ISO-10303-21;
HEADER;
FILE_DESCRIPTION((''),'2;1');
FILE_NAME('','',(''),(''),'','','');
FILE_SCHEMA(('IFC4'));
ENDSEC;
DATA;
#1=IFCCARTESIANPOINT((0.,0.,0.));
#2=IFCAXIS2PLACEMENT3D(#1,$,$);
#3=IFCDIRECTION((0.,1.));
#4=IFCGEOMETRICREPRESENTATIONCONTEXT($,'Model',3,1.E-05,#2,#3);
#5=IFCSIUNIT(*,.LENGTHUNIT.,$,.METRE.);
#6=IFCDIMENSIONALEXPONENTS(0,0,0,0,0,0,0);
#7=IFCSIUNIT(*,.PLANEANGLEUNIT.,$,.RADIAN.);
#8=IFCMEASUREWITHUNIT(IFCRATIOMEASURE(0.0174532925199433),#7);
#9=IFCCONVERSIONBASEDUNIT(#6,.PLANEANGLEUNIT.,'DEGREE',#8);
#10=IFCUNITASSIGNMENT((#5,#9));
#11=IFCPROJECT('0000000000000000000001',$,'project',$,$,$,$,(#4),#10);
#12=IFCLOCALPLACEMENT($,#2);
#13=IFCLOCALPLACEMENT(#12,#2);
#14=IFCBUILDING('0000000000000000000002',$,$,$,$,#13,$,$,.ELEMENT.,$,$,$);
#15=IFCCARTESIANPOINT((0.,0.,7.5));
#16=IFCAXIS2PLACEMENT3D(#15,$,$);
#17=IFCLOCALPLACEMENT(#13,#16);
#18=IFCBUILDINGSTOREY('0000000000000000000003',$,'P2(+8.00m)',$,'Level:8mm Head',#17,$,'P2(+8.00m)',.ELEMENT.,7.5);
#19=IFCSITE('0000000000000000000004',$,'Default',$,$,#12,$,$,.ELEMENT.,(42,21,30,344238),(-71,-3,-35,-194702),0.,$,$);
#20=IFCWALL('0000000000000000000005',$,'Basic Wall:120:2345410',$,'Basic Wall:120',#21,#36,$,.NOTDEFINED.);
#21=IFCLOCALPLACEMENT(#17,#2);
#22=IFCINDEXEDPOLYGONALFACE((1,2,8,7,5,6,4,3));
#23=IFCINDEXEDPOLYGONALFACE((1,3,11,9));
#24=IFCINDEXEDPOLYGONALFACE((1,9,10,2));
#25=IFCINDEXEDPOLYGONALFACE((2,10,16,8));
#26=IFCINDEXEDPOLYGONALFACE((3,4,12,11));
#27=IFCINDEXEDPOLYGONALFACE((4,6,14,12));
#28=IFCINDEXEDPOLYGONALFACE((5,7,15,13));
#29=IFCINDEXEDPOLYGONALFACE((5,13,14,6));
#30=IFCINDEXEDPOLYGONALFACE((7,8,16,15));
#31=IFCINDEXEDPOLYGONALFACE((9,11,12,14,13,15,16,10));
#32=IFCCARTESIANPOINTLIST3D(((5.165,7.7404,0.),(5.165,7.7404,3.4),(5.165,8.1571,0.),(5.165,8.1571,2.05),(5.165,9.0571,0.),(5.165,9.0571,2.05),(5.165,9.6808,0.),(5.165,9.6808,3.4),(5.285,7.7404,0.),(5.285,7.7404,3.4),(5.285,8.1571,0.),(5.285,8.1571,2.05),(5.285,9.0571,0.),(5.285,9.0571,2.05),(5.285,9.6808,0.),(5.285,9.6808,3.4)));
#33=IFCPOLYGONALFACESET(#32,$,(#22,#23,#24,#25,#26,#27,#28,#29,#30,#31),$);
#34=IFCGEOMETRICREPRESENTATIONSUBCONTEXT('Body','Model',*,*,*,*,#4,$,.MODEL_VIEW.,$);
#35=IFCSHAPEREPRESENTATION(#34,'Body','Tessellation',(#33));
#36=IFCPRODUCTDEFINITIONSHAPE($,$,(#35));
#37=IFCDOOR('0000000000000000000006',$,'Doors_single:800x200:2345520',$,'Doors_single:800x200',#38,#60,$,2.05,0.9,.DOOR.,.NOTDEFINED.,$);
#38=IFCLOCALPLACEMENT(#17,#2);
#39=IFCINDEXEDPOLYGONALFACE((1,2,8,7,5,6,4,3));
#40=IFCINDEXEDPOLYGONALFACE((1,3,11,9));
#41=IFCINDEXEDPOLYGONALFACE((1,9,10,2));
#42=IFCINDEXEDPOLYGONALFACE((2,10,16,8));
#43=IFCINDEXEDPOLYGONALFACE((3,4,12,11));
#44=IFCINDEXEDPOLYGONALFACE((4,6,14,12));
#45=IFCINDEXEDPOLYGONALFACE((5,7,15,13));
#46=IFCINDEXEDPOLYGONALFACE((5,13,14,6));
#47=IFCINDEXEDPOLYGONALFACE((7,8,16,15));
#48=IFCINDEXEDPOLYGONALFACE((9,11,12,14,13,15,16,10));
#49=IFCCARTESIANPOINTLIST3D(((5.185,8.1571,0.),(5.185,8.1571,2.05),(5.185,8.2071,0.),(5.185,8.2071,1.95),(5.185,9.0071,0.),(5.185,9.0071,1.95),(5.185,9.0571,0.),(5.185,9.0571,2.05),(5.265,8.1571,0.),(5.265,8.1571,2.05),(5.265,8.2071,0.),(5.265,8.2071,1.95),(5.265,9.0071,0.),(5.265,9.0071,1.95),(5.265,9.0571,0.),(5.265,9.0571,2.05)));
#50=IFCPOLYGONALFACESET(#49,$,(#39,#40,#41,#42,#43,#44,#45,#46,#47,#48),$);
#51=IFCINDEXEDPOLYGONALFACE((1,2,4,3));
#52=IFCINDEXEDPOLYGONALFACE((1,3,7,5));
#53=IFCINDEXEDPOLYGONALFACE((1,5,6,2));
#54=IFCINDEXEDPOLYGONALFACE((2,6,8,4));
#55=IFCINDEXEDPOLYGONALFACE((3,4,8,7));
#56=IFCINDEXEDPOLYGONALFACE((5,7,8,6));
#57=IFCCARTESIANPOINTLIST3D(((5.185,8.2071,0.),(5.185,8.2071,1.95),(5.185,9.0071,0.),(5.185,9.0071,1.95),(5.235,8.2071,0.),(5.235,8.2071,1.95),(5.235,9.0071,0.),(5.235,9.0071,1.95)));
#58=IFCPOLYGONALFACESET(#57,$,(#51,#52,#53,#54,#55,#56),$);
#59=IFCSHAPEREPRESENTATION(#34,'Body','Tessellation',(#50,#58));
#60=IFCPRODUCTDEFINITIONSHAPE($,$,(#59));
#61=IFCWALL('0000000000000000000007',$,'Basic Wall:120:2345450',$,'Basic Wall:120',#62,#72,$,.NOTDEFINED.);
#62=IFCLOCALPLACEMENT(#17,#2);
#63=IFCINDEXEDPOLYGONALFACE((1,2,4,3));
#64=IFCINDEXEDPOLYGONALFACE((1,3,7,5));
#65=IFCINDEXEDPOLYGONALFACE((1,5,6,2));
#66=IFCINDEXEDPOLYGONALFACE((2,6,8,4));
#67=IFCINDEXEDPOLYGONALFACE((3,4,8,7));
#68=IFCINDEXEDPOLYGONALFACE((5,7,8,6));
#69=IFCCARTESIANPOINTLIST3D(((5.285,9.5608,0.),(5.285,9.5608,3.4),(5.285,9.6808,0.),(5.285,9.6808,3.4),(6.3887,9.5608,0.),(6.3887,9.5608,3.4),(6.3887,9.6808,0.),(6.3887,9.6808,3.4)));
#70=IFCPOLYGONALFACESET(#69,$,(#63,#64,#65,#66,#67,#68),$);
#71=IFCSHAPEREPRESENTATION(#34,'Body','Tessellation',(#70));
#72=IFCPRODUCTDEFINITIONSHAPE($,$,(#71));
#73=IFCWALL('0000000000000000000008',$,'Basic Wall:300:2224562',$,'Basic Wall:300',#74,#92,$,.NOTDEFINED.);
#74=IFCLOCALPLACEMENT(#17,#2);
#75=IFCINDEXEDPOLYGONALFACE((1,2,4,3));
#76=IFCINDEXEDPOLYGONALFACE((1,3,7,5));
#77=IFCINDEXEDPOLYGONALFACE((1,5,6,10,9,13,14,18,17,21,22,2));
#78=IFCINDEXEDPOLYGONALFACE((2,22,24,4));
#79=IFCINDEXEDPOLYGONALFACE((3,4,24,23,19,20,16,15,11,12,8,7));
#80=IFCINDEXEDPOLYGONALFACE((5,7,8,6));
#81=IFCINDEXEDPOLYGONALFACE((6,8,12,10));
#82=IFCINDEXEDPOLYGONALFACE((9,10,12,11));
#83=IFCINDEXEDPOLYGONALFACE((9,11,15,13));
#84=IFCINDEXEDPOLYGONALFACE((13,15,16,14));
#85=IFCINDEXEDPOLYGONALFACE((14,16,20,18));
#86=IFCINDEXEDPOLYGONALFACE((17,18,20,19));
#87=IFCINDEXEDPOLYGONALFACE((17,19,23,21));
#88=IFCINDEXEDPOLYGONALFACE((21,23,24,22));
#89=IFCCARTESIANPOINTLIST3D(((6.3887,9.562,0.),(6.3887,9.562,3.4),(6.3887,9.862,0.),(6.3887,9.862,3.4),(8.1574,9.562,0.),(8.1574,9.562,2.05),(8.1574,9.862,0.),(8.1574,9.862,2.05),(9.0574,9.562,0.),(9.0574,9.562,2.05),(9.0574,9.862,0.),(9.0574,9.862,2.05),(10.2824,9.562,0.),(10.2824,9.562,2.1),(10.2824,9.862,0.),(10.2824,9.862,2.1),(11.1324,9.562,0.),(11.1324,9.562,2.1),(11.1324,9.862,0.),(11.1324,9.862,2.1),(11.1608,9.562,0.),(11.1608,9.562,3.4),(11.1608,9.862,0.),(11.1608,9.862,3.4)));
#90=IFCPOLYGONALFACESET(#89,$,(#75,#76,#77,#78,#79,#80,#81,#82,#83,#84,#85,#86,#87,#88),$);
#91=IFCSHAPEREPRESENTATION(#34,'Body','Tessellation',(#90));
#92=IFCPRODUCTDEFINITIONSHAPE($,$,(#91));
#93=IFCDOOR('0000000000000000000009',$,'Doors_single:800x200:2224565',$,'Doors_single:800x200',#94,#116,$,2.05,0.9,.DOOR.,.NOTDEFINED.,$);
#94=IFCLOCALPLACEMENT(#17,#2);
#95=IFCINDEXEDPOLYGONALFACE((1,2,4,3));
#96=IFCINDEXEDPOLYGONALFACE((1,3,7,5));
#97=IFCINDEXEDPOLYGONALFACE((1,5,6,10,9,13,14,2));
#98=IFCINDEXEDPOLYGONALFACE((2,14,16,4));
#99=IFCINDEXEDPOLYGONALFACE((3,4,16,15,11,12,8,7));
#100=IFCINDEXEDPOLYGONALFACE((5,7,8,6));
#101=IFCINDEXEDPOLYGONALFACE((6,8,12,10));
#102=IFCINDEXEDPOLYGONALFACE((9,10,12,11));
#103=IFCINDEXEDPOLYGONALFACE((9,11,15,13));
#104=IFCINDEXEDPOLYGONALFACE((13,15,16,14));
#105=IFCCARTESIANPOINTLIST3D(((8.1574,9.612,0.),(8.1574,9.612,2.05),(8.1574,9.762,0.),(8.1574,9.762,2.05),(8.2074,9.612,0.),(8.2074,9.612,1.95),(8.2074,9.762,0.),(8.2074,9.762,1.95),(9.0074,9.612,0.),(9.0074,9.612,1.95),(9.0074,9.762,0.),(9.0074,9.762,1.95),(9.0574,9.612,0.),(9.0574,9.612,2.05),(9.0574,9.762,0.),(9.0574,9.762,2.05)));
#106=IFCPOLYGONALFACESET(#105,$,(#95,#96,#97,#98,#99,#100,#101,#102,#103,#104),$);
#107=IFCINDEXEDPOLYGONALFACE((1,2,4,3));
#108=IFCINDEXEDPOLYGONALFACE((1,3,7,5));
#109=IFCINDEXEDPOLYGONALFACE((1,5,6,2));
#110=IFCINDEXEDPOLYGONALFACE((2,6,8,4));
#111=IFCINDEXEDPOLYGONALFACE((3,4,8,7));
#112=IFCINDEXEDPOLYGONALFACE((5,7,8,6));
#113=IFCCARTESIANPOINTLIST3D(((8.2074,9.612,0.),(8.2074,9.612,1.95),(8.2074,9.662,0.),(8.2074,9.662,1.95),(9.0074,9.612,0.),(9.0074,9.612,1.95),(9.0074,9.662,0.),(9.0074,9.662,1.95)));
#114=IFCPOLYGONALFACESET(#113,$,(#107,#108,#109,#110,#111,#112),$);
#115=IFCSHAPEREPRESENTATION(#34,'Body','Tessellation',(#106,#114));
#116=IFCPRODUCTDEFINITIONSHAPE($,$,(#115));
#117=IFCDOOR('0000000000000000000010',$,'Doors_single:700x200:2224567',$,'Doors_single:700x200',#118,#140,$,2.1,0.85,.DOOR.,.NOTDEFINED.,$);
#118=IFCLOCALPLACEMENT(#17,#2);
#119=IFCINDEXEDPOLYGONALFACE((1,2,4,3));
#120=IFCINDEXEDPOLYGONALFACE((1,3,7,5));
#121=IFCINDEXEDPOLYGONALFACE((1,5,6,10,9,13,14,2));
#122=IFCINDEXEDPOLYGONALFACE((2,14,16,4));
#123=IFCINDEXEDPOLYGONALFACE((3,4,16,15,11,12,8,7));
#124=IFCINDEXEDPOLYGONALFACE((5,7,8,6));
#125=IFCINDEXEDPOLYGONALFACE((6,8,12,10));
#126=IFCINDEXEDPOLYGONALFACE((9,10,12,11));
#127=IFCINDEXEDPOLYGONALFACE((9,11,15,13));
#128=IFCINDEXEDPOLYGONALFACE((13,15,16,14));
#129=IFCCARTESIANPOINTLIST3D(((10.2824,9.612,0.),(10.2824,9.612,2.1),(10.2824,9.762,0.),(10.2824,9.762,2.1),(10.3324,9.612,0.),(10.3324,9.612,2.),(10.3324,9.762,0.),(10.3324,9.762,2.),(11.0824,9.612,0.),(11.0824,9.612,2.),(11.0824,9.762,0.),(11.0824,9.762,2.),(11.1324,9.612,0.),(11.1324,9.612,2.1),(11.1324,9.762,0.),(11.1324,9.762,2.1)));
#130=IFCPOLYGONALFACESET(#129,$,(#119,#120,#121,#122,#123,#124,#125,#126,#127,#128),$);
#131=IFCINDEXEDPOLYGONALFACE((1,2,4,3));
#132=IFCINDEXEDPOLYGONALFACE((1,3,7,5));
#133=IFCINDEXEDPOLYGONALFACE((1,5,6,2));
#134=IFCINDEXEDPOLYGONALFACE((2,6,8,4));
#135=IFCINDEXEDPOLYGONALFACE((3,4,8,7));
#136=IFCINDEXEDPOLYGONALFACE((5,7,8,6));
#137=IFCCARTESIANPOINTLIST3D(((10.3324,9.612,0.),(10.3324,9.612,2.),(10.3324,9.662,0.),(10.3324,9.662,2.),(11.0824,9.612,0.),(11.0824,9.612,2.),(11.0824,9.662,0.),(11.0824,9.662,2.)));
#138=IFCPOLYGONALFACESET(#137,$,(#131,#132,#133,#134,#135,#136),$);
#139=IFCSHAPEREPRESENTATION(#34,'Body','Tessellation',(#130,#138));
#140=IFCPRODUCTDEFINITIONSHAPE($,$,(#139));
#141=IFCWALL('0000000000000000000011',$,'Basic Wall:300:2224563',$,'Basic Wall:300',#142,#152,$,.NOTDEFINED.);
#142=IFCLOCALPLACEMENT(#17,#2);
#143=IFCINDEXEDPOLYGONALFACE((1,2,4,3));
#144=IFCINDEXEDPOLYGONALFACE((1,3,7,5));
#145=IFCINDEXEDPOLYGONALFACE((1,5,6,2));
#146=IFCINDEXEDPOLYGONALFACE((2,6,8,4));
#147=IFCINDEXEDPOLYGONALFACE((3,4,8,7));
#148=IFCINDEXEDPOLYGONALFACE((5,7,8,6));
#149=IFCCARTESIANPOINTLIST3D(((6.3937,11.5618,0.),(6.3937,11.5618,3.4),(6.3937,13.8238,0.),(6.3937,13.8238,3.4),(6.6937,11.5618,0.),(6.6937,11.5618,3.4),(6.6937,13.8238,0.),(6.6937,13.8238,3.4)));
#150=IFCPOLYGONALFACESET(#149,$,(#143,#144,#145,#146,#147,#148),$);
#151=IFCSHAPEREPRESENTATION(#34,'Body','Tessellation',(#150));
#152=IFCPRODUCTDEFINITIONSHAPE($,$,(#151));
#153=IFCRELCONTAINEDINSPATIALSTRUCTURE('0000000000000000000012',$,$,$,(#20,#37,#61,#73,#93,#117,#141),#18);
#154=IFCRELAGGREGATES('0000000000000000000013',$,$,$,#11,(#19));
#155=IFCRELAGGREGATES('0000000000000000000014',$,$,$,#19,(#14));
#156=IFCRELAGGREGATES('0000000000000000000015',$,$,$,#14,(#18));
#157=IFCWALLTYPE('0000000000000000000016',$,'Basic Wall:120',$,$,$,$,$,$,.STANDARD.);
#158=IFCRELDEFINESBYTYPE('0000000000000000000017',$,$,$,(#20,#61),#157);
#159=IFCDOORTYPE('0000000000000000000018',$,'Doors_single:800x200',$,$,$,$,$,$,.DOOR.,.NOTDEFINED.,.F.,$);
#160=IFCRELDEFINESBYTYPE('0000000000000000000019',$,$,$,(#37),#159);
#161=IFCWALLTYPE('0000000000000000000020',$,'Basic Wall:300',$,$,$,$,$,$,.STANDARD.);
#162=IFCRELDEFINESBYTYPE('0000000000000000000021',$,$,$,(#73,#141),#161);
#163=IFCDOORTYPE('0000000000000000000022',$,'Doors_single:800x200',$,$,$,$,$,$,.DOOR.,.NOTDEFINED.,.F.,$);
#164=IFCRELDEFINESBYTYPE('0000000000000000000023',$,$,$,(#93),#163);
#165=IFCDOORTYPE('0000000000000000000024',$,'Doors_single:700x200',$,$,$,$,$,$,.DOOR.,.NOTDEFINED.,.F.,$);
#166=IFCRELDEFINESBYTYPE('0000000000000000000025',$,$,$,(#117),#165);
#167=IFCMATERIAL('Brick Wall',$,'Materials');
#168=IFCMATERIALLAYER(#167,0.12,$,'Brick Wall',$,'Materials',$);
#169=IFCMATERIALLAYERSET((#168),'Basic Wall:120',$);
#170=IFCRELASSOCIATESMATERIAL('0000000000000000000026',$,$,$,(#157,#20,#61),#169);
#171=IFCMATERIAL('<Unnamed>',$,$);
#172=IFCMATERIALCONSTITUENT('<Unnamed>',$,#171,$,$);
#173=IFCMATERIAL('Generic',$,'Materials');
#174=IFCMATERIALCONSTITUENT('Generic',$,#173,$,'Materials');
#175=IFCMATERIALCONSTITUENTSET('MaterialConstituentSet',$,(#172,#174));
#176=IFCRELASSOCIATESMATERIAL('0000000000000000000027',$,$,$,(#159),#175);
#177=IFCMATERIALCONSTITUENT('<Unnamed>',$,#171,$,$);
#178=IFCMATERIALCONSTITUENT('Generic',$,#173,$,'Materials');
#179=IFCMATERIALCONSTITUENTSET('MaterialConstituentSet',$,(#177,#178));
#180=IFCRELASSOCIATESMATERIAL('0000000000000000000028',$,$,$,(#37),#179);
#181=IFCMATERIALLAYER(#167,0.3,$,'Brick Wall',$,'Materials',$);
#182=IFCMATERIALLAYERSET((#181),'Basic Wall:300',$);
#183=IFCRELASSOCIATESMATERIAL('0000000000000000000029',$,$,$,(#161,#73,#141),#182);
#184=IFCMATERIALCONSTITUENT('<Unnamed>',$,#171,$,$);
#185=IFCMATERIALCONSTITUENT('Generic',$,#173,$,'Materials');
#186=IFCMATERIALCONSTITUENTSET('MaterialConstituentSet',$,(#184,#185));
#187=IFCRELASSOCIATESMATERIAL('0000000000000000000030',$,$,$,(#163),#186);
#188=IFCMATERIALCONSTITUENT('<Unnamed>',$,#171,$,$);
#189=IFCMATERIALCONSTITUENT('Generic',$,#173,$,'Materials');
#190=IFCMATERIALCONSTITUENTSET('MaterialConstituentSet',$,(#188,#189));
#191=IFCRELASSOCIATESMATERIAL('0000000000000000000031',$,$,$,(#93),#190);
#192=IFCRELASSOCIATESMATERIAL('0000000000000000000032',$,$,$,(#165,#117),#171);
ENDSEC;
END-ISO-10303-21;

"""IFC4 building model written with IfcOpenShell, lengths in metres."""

from ifc_helpers import new_model, entity, si_unit, converted_unit, direction, frame, frame_2d, origin, origin_2d_with_axis, place, context, subcontext, project, spatial, polyline, rectangle, outline, extrude, source, transform, mapped, material, layer, layer_set, layer_usage, constituent, constituent_set, type_object, type_shapes, element, fill, save


model = new_model("IFC4")

# Units and contexts
model_context = context("Model", 3, precision=1e-05, world=origin(), true_north=direction((0.0, 1.0)))
body_context = subcontext(model_context, "Body", "Model", "MODEL_VIEW")
ifc_project = project(units=[si_unit("LENGTHUNIT", "METRE"), converted_unit("PLANEANGLEUNIT", "DEGREE", entity("IfcRatioMeasure", 0.0174532925199433), si_unit("PLANEANGLEUNIT", "RADIAN"), dimensions=[0, 0, 0, 0, 0, 0, 0])], contexts=[model_context])

# Site, building, storey
site_placement = place(None, origin())
site = spatial("IfcSite", under=ifc_project, at=site_placement, Name="Default", CompositionType="ELEMENT", RefLatitude=(42, 21, 30, 344238), RefLongitude=(-71, -3, -35, -194702), RefElevation=0.0)
building_placement = place(site_placement, origin())
building = spatial("IfcBuilding", under=site, at=building_placement, CompositionType="ELEMENT")
storey_placement = place(building_placement, frame((0.0, 0.0, 7.5)))
storey = spatial("IfcBuildingStorey", under=building, at=storey_placement, Name="P2(+8.00m)", ObjectType="Level:8mm Head", LongName="P2(+8.00m)", CompositionType="ELEMENT", Elevation=7.5)

# Shared definitions
ifc_material_1 = material(Name="Brick Wall", Category="Materials")
ifc_material_2 = material(Name="<Unnamed>")
ifc_material_3 = material(Name="Generic", Category="Materials")

# Shared definitions
ifc_layer_1 = layer(ifc_material_1, 0.12, Name="Brick Wall", Category="Materials")
ifc_layer_set_1 = layer_set([ifc_layer_1], Name="Basic Wall:120")
wall_type_1 = type_object("IfcWallType", Name="Basic Wall:120", PredefinedType="STANDARD", material=ifc_layer_set_1)

# Wall, opening, door
ifc_layer_usage_1 = layer_usage(ifc_layer_set_1, "AXIS2", "NEGATIVE", 0.06)
wall_1_placement = place(storey_placement, frame((5.225, 7.7404, 0.0), z_axis=(0.0, 0.0, 1.0), x_axis=(0.0, 1.0, 0.0)))
wall_1 = element("IfcWall", 1, at=wall_1_placement, inside=storey, type_object=wall_type_1, material=ifc_layer_usage_1, Name="Basic Wall:120:2345410", ObjectType="Basic Wall:120", PredefinedType="NOTDEFINED", context=body_context, shape_type="SweptSolid", body=[
    extrude(rectangle(XDim=1.9404, YDim=0.12, at=frame_2d((0.9702, 0.0), x_axis=(-1.0, 0.0))), origin(), (0.0, 0.0, 1.0), 3.4),
])
opening_1_placement = place(wall_1_placement, frame((0.4168, -0.06, 0.0)))
opening_1 = element("IfcOpeningElement", 2, at=opening_1_placement, cuts=wall_1, PredefinedType="OPENING", context=body_context, shape_type="SweptSolid", body=[
    extrude(rectangle(XDim=2.05, YDim=0.9, at=frame_2d((1.025, 0.45), x_axis=(1.0, 0.0))), frame((0.0, 0.0, 0.0), z_axis=(0.0, 1.0, 0.0), x_axis=(0.0, 0.0, 1.0)), (0.0, 0.0, 1.0), 0.12),
])
ifc_constituent_1 = constituent(ifc_material_2, Name="<Unnamed>")
ifc_constituent_2 = constituent(ifc_material_3, Name="Generic", Category="Materials")
ifc_constituent_set_1 = constituent_set(constituents=[ifc_constituent_1, ifc_constituent_2], Name="MaterialConstituentSet")
ifc_constituent_3 = constituent(ifc_material_2, Name="<Unnamed>")
ifc_constituent_4 = constituent(ifc_material_3, Name="Generic", Category="Materials")
ifc_constituent_set_2 = constituent_set(constituents=[ifc_constituent_3, ifc_constituent_4], Name="MaterialConstituentSet")
door_type_1 = type_object("IfcDoorType", Name="Doors_single:800x200", OperationType="NOTDEFINED", ParameterTakesPrecedence=False, PredefinedType="DOOR", material=ifc_constituent_set_2)
shared_shape_1 = source(origin(), body_context, "Body", "SweptSolid", [
    extrude(outline(polyline([(-0.45, -1.0), (-0.4, -1.0), (-0.4, 0.95), (0.4, 0.95), (0.4, -1.0), (0.45, -1.0), (0.45, 1.05), (-0.45, 1.05), (-0.45, -1.0)])), frame((0.45, 0.02, 1.0), z_axis=(0.0, 1.0, 0.0), x_axis=(-1.0, 0.0, 0.0)), (0.0, 0.0, 1.0), 0.08),
    extrude(rectangle(XDim=0.8, YDim=0.05, at=origin_2d_with_axis()), frame((0.45, 0.075, 0.0), z_axis=(0.0, 0.0, 1.0), x_axis=(-1.0, 0.0, 0.0)), (0.0, 0.0, 1.0), 1.95),
])
type_shapes(door_type_1, [shared_shape_1])
door_1_placement = place(opening_1_placement, origin())
door_1 = element("IfcDoor", 3, at=door_1_placement, inside=storey, type_object=door_type_1, material=ifc_constituent_set_1, Name="Doors_single:800x200:2345520", ObjectType="Doors_single:800x200", OperationType="NOTDEFINED", OverallHeight=2.05, OverallWidth=0.9, PredefinedType="DOOR", context=body_context, shape_type="MappedRepresentation", body=[
    mapped(shared_shape_1, transform((0.0, 0.0, 0.0), scale=1.0)),
])
fill(opening_1, door_1)

# Wall
ifc_layer_usage_2 = layer_usage(ifc_layer_set_1, "AXIS2", "NEGATIVE", 0.06)
wall_2_placement = place(storey_placement, frame((5.285, 9.6208, 0.0)))
element("IfcWall", 4, at=wall_2_placement, inside=storey, type_object=wall_type_1, material=ifc_layer_usage_2, Name="Basic Wall:120:2345450", ObjectType="Basic Wall:120", PredefinedType="NOTDEFINED", context=body_context, shape_type="SweptSolid", body=[
    extrude(rectangle(XDim=1.1037, YDim=0.12, at=frame_2d((0.5518, 0.0), x_axis=(-1.0, 0.0))), origin(), (0.0, 0.0, 1.0), 3.4),
])

# Wall, openings, doors
ifc_layer_2 = layer(ifc_material_1, 0.3, Name="Brick Wall", Category="Materials")
ifc_layer_set_2 = layer_set([ifc_layer_2], Name="Basic Wall:300")
ifc_layer_usage_3 = layer_usage(ifc_layer_set_2, "AXIS2", "NEGATIVE", 0.15)
wall_type_2 = type_object("IfcWallType", Name="Basic Wall:300", PredefinedType="STANDARD", material=ifc_layer_set_2)
wall_3_placement = place(storey_placement, frame((11.1608, 9.712, 0.0), z_axis=(0.0, 0.0, 1.0), x_axis=(-1.0, 0.0, 0.0)))
wall_3 = element("IfcWall", 5, at=wall_3_placement, inside=storey, type_object=wall_type_2, material=ifc_layer_usage_3, Name="Basic Wall:300:2224562", ObjectType="Basic Wall:300", PredefinedType="NOTDEFINED", context=body_context, shape_type="SweptSolid", body=[
    extrude(rectangle(XDim=4.7721, YDim=0.3, at=frame_2d((2.3861, 0.0), x_axis=(-1.0, 0.0))), origin(), (0.0, 0.0, 1.0), 3.4),
])
opening_2_placement = place(wall_3_placement, frame((0.0284, -0.15, 0.0)))
opening_2 = element("IfcOpeningElement", 6, at=opening_2_placement, cuts=wall_3, PredefinedType="OPENING", context=body_context, shape_type="SweptSolid", body=[
    extrude(rectangle(XDim=2.1, YDim=0.85, at=frame_2d((1.05, 0.425), x_axis=(1.0, 0.0))), frame((0.0, 0.0, 0.0), z_axis=(0.0, 1.0, 0.0), x_axis=(0.0, 0.0, 1.0)), (0.0, 0.0, 1.0), 0.3),
])
opening_3_placement = place(wall_3_placement, frame((2.1034, -0.15, 0.0)))
opening_3 = element("IfcOpeningElement", 7, at=opening_3_placement, cuts=wall_3, PredefinedType="OPENING", context=body_context, shape_type="SweptSolid", body=[
    extrude(rectangle(XDim=2.05, YDim=0.9, at=frame_2d((1.025, 0.45), x_axis=(1.0, 0.0))), frame((0.0, 0.0, 0.0), z_axis=(0.0, 1.0, 0.0), x_axis=(0.0, 0.0, 1.0)), (0.0, 0.0, 1.0), 0.3),
])
ifc_constituent_5 = constituent(ifc_material_2, Name="<Unnamed>")
ifc_constituent_6 = constituent(ifc_material_3, Name="Generic", Category="Materials")
ifc_constituent_set_3 = constituent_set(constituents=[ifc_constituent_5, ifc_constituent_6], Name="MaterialConstituentSet")
ifc_constituent_7 = constituent(ifc_material_2, Name="<Unnamed>")
ifc_constituent_8 = constituent(ifc_material_3, Name="Generic", Category="Materials")
ifc_constituent_set_4 = constituent_set(constituents=[ifc_constituent_7, ifc_constituent_8], Name="MaterialConstituentSet")
door_type_2 = type_object("IfcDoorType", Name="Doors_single:800x200", OperationType="NOTDEFINED", ParameterTakesPrecedence=False, PredefinedType="DOOR", material=ifc_constituent_set_4)
shared_shape_2 = source(origin(), body_context, "Body", "SweptSolid", [
    extrude(outline(polyline([(-0.45, -1.0), (-0.4, -1.0), (-0.4, 0.95), (0.4, 0.95), (0.4, -1.0), (0.45, -1.0), (0.45, 1.05), (-0.45, 1.05), (-0.45, -1.0)])), frame((0.45, 0.1, 1.0), z_axis=(0.0, 1.0, 0.0), x_axis=(-1.0, 0.0, 0.0)), (0.0, 0.0, 1.0), 0.15),
    extrude(rectangle(XDim=0.8, YDim=0.05, at=frame_2d((0.0, 0.0), x_axis=(1.0, 0.0))), frame((0.45, 0.225, 0.0), z_axis=(0.0, 0.0, 1.0), x_axis=(-1.0, 0.0, 0.0)), (0.0, 0.0, 1.0), 1.95),
])
type_shapes(door_type_2, [shared_shape_2])
door_2_placement = place(opening_3_placement, origin())
door_2 = element("IfcDoor", 8, at=door_2_placement, inside=storey, type_object=door_type_2, material=ifc_constituent_set_3, Name="Doors_single:800x200:2224565", ObjectType="Doors_single:800x200", OperationType="NOTDEFINED", OverallHeight=2.05, OverallWidth=0.9, PredefinedType="DOOR", context=body_context, shape_type="MappedRepresentation", body=[
    mapped(shared_shape_2, transform((0.0, 0.0, 0.0), scale=1.0)),
])
fill(opening_3, door_2)
door_type_3 = type_object("IfcDoorType", Name="Doors_single:700x200", OperationType="NOTDEFINED", ParameterTakesPrecedence=False, PredefinedType="DOOR", material=ifc_material_2)
shared_shape_3 = source(origin(), body_context, "Body", "SweptSolid", [
    extrude(outline(polyline([(-0.425, -1.025), (-0.375, -1.025), (-0.375, 0.975), (0.375, 0.975), (0.375, -1.025), (0.425, -1.025), (0.425, 1.075), (-0.425, 1.075), (-0.425, -1.025)])), frame((0.425, 0.1, 1.025), z_axis=(0.0, 1.0, 0.0), x_axis=(-1.0, 0.0, 0.0)), (0.0, 0.0, 1.0), 0.15),
    extrude(rectangle(XDim=0.75, YDim=0.05, at=frame_2d((0.0, 0.0), x_axis=(1.0, 0.0))), frame((0.425, 0.225, 0.0), z_axis=(0.0, 0.0, 1.0), x_axis=(-1.0, 0.0, 0.0)), (0.0, 0.0, 1.0), 2.0),
])
type_shapes(door_type_3, [shared_shape_3])
door_3_placement = place(opening_2_placement, origin())
door_3 = element("IfcDoor", 9, at=door_3_placement, inside=storey, type_object=door_type_3, material=ifc_material_2, Name="Doors_single:700x200:2224567", ObjectType="Doors_single:700x200", OperationType="NOTDEFINED", OverallHeight=2.1, OverallWidth=0.85, PredefinedType="DOOR", context=body_context, shape_type="MappedRepresentation", body=[
    mapped(shared_shape_3, transform((0.0, 0.0, 0.0), scale=1.0)),
])
fill(opening_2, door_3)

# Wall
ifc_layer_usage_4 = layer_usage(ifc_layer_set_2, "AXIS2", "NEGATIVE", 0.15)
wall_4_placement = place(storey_placement, frame((6.5437, 11.5618, 0.0), z_axis=(0.0, 0.0, 1.0), x_axis=(0.0, 1.0, 0.0)))
element("IfcWall", 10, at=wall_4_placement, inside=storey, type_object=wall_type_2, material=ifc_layer_usage_4, Name="Basic Wall:300:2224563", ObjectType="Basic Wall:300", PredefinedType="NOTDEFINED", context=body_context, shape_type="SweptSolid", body=[
    extrude(rectangle(XDim=2.2621, YDim=0.3, at=frame_2d((1.131, 0.0), x_axis=(-1.0, 0.0))), origin(), (0.0, 0.0, 1.0), 3.4),
])

save(model, "model.ifc")
